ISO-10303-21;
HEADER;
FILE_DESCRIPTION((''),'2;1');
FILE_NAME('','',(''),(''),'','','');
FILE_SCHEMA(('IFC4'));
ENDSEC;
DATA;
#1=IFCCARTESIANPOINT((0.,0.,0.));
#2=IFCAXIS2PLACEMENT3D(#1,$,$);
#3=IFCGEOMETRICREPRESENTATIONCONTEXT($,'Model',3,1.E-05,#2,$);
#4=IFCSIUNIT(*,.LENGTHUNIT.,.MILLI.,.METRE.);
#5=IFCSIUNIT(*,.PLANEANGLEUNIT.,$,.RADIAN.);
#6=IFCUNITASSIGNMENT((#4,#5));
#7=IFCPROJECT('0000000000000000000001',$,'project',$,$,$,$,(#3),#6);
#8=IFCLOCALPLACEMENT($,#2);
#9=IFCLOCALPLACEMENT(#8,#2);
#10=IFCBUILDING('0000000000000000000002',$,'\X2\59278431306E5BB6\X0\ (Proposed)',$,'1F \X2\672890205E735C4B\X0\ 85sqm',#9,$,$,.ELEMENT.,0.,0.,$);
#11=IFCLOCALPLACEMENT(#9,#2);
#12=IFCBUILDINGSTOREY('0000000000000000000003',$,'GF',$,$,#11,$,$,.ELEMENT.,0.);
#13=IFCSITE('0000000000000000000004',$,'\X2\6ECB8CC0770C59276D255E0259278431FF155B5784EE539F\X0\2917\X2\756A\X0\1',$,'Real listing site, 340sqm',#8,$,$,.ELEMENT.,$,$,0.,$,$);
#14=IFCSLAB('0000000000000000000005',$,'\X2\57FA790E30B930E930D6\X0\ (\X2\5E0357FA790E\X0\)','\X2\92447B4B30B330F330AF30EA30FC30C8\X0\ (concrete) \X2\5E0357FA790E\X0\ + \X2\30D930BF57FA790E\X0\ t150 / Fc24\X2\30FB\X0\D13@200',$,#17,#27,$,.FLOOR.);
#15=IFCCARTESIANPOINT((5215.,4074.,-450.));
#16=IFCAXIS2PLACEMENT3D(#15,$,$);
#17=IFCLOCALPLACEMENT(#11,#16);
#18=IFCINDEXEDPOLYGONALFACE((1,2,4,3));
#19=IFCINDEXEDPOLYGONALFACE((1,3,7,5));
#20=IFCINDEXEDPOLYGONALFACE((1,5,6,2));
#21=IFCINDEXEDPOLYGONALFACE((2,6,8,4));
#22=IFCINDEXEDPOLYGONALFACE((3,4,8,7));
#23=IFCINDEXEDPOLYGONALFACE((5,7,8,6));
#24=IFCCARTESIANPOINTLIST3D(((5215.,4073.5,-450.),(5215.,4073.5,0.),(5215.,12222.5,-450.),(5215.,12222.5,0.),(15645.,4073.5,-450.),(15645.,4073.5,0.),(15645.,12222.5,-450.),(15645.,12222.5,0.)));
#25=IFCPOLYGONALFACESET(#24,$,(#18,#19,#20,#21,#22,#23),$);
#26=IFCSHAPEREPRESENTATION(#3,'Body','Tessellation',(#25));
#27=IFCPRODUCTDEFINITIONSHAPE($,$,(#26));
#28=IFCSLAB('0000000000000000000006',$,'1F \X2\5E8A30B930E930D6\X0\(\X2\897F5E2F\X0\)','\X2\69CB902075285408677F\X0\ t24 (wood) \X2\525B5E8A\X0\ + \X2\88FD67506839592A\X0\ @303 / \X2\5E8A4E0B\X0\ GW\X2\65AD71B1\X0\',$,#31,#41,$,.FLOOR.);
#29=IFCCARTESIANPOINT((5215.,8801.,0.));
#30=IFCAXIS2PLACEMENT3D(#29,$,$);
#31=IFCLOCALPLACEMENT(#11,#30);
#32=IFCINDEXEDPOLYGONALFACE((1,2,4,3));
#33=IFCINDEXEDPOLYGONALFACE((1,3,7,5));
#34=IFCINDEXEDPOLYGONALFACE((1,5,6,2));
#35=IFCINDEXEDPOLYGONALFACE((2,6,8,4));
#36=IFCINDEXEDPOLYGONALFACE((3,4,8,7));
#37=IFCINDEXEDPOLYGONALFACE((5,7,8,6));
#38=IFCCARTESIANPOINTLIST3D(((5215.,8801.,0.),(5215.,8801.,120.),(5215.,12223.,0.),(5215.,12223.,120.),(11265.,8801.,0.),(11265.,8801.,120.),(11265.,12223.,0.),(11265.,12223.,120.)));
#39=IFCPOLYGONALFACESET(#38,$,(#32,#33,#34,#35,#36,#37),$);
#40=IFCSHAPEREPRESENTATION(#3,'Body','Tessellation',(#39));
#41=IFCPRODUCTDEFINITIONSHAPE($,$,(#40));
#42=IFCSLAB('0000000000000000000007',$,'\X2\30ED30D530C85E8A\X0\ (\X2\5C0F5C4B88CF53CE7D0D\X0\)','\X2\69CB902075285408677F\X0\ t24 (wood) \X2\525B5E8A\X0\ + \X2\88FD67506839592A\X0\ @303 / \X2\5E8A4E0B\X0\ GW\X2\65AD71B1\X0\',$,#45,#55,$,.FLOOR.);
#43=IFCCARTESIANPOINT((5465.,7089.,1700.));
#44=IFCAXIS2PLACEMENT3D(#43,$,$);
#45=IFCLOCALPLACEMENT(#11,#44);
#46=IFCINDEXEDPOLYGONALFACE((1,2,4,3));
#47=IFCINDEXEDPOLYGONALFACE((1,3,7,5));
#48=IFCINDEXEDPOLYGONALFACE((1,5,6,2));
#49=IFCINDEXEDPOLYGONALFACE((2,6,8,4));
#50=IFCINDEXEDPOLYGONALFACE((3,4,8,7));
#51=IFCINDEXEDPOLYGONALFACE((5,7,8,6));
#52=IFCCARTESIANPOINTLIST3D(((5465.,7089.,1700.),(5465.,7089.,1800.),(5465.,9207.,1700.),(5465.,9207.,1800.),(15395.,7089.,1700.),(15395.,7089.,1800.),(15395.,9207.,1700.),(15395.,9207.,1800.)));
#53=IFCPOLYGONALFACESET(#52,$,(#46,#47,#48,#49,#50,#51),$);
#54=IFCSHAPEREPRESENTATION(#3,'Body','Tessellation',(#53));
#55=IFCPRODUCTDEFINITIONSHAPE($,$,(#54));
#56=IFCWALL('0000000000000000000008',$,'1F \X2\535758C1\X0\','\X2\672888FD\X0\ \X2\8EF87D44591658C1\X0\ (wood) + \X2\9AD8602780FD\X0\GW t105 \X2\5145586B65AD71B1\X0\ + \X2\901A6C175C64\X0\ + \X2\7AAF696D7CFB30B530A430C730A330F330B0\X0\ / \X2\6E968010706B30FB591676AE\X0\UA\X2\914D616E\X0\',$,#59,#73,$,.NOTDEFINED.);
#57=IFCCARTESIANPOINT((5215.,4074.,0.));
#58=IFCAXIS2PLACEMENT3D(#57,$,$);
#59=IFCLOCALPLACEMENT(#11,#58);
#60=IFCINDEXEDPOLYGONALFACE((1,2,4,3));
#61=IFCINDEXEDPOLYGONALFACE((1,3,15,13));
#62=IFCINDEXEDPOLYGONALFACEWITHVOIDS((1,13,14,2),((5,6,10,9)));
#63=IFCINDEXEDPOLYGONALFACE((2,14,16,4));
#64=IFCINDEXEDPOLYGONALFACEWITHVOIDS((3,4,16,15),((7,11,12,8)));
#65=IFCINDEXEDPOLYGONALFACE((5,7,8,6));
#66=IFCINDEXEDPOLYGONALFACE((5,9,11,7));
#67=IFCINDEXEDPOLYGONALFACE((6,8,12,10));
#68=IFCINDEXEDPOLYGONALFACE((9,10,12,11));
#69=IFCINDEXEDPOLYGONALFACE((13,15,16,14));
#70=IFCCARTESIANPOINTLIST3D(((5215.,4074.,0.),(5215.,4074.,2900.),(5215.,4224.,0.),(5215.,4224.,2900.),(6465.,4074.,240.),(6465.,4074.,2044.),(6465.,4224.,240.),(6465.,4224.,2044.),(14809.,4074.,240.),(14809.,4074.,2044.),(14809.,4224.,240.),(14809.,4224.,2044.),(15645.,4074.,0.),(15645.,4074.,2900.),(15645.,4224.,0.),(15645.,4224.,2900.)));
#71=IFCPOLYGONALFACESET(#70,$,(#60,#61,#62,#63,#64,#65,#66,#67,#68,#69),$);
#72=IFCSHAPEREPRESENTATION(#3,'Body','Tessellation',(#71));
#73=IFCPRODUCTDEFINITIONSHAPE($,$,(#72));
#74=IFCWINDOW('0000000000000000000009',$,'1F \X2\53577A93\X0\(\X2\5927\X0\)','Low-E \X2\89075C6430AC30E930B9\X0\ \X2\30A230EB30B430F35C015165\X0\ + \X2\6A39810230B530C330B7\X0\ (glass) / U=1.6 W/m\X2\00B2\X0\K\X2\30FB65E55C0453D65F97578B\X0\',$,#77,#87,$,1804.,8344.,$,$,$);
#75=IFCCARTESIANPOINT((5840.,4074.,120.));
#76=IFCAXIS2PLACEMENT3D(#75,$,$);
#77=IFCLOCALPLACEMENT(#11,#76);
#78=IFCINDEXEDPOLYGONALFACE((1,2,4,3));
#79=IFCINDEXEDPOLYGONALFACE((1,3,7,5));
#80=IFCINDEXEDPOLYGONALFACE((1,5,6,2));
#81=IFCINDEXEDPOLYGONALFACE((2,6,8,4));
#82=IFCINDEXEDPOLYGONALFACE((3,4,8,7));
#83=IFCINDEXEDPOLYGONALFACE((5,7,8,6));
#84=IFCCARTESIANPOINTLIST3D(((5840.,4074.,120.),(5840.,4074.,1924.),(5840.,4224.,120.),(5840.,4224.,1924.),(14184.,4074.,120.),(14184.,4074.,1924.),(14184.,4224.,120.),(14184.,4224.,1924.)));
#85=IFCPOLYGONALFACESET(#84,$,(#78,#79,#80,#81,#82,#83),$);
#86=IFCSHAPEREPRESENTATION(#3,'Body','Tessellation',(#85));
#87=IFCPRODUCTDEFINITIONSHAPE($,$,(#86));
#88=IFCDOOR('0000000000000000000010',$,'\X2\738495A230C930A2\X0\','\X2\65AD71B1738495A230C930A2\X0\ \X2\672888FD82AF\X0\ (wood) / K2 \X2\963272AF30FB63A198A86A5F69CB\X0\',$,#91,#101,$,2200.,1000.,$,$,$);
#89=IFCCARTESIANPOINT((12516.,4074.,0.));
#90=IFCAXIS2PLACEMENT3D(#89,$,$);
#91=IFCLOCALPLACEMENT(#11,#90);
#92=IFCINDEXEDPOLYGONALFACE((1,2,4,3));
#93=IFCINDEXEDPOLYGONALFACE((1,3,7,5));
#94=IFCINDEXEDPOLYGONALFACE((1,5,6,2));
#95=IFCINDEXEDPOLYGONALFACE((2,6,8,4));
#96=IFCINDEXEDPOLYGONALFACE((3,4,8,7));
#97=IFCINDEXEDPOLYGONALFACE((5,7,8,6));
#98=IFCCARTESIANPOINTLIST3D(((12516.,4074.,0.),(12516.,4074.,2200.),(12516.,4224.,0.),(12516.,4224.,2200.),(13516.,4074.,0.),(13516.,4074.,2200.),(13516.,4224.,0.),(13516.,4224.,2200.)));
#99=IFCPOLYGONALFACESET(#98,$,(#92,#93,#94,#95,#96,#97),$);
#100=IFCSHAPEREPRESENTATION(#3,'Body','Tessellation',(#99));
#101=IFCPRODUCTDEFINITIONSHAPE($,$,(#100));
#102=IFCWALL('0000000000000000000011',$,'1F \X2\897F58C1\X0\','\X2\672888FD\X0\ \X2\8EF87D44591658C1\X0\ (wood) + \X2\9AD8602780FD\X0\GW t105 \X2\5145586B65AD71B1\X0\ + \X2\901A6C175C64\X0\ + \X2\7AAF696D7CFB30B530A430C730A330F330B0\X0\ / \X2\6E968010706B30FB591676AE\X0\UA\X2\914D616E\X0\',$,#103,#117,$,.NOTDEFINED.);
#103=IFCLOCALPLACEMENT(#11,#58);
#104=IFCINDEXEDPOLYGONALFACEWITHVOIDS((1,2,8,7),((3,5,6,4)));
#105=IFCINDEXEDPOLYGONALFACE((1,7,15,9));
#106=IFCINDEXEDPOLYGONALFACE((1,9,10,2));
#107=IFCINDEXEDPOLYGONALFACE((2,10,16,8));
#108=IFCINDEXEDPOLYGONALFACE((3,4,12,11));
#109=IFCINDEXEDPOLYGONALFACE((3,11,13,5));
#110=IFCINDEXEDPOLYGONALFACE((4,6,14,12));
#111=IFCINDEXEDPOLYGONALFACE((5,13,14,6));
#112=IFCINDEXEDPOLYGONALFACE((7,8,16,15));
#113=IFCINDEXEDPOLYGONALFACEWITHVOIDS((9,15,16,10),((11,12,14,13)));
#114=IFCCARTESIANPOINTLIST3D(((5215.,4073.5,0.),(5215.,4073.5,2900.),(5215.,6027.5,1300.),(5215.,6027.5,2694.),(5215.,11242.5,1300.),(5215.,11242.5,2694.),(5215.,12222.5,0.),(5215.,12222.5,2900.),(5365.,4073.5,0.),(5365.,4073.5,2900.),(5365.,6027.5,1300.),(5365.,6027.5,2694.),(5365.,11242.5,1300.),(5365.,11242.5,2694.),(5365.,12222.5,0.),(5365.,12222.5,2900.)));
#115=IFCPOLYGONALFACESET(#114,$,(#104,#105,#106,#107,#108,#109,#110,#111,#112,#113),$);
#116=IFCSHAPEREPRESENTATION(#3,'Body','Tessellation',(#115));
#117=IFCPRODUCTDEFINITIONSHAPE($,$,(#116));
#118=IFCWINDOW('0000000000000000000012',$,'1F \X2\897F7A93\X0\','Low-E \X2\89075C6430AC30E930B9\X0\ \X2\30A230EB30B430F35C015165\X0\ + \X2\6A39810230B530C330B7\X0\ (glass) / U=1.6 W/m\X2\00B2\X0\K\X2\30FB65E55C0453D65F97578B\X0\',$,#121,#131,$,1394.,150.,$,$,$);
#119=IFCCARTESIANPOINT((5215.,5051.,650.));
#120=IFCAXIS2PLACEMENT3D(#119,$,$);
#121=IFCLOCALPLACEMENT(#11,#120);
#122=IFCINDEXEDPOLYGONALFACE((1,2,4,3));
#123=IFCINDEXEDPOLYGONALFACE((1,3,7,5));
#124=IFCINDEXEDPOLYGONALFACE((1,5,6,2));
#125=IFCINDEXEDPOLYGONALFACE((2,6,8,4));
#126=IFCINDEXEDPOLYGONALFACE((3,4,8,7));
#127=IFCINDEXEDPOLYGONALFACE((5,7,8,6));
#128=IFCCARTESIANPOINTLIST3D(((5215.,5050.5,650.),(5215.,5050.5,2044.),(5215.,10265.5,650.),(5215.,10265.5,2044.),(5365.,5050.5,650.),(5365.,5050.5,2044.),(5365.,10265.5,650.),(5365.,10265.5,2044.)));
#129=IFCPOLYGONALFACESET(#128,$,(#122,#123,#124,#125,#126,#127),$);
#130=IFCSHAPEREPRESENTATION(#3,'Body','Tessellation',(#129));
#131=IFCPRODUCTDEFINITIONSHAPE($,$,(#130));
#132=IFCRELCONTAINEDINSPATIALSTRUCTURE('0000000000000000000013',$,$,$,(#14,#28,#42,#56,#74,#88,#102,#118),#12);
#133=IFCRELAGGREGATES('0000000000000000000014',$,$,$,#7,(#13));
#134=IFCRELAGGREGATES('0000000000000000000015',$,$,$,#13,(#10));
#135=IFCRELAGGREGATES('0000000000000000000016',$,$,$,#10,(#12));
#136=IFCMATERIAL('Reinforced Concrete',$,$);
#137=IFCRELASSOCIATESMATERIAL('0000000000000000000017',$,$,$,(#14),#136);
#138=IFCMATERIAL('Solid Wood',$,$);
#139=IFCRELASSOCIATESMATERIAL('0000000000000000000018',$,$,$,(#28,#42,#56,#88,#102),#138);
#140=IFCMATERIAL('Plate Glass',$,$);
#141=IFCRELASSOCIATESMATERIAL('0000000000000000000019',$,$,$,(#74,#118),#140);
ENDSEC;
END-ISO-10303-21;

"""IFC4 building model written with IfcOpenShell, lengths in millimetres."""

from ifc_helpers import new_model, si_unit, frame, frame_2d, origin, place, context, project, spatial, rectangle, extrude, material, element, fill, save


model = new_model("IFC4")

# Units and contexts
model_context = context("Model", 3, precision=1e-05, world=origin())
ifc_project = project(units=[si_unit("LENGTHUNIT", "METRE", prefix="MILLI"), si_unit("PLANEANGLEUNIT", "RADIAN")], contexts=[model_context])

# Site, building, storey
site_placement = place(None, origin())
site = spatial("IfcSite", under=ifc_project, at=site_placement, Name="滋賀県大津市大萱５字蓮原2917番1", ObjectType="Real listing site, 340sqm", CompositionType="ELEMENT", RefElevation=0.0)
building_placement = place(site_placement, origin())
building = spatial("IfcBuilding", under=site, at=building_placement, Name="大萱の家 (Proposed)", ObjectType="1F 木造平屋 85sqm", CompositionType="ELEMENT", ElevationOfRefHeight=0.0, ElevationOfTerrain=0.0)
storey_placement = place(building_placement, origin())
storey = spatial("IfcBuildingStorey", under=building, at=storey_placement, Name="GF", CompositionType="ELEMENT", Elevation=0.0)

# Slabs
ifc_material_1 = material(Name="Reinforced Concrete")
slab_1_placement = place(storey_placement, frame((5215.0, 4074.0, -450.0)))
element("IfcSlab", 1, at=slab_1_placement, inside=storey, material=ifc_material_1, Name="基礎スラブ (布基礎)", Description="鉄筋コンクリート (concrete) 布基礎 + ベタ基礎 t150 / Fc24・D13@200", PredefinedType="FLOOR", context=model_context, shape_type="SweptSolid", body=[
    extrude(rectangle(XDim=10430.0, YDim=8149.0, at=frame_2d((5215.0, 4074.0))), frame((5215.0, 4074.0, -450.0)), (0.0, 0.0, 1.0), 450.0),
])
ifc_material_2 = material(Name="Solid Wood")
slab_2_placement = place(storey_placement, frame((5215.0, 8801.0, 0.0)))
element("IfcSlab", 2, at=slab_2_placement, inside=storey, material=ifc_material_2, Name="1F 床スラブ(西帯)", Description="構造用合板 t24 (wood) 剛床 + 製材根太 @303 / 床下 GW断熱", PredefinedType="FLOOR", context=model_context, shape_type="SweptSolid", body=[
    extrude(rectangle(XDim=6050.0, YDim=3422.0, at=frame_2d((3025.0, 1711.0))), frame((5215.0, 8801.0, 0.0)), (0.0, 0.0, 1.0), 120.0),
])
slab_3_placement = place(storey_placement, frame((5465.0, 7089.0, 1700.0)))
element("IfcSlab", 3, at=slab_3_placement, inside=storey, material=ifc_material_2, Name="ロフト床 (小屋裏収納)", Description="構造用合板 t24 (wood) 剛床 + 製材根太 @303 / 床下 GW断熱", PredefinedType="FLOOR", context=model_context, shape_type="SweptSolid", body=[
    extrude(rectangle(XDim=9930.0, YDim=2118.0, at=frame_2d((4965.0, 1059.0))), frame((5465.0, 7089.0, 1700.0)), (0.0, 0.0, 1.0), 100.0),
])

# Wall, openings, window, door
wall_1_placement = place(storey_placement, frame((5215.0, 4074.0, 0.0)))
wall_1 = element("IfcWall", 4, at=wall_1_placement, inside=storey, material=ifc_material_2, Name="1F 南壁", Description="木製 軸組外壁 (wood) + 高性能GW t105 充填断熱 + 通気層 + 窯業系サイディング / 準耐火・外皮UA配慮", PredefinedType="NOTDEFINED", context=model_context, shape_type="SweptSolid", body=[
    extrude(rectangle(XDim=10430.0, YDim=150.0, at=frame_2d((5215.0, 75.0))), frame((5215.0, 4074.0, 0.0)), (0.0, 0.0, 1.0), 2900.0),
])
opening_1_placement = place(storey_placement, frame((5840.0, 4074.0, 120.0)))
opening_1 = element("IfcOpeningElement", 5, at=opening_1_placement, cuts=wall_1, PredefinedType="NOTDEFINED", context=model_context, shape_type="SweptSolid", body=[
    extrude(rectangle(XDim=8344.0, YDim=150.0, at=frame_2d((4172.0, 75.0))), frame((5840.0, 4074.0, 120.0)), (0.0, 0.0, 1.0), 1804.0),
])
opening_2_placement = place(storey_placement, frame((12516.0, 4074.0, 0.0)))
opening_2 = element("IfcOpeningElement", 6, at=opening_2_placement, cuts=wall_1, PredefinedType="NOTDEFINED", context=model_context, shape_type="SweptSolid", body=[
    extrude(rectangle(XDim=1000.0, YDim=150.0, at=frame_2d((500.0, 75.0))), frame((12516.0, 4074.0, 0.0)), (0.0, 0.0, 1.0), 2200.0),
])
ifc_material_3 = material(Name="Plate Glass")
window_1_placement = place(storey_placement, frame((5840.0, 4074.0, 120.0)))
window_1 = element("IfcWindow", 7, at=window_1_placement, inside=storey, material=ifc_material_3, Name="1F 南窓(大)", Description="Low-E 複層ガラス アルゴン封入 + 樹脂サッシ (glass) / U=1.6 W/m²K・日射取得型", OverallHeight=1804.0, OverallWidth=8344.0, context=model_context, shape_type="SweptSolid", body=[
    extrude(rectangle(XDim=8344.0, YDim=150.0, at=frame_2d((4172.0, 75.0))), frame((5840.0, 4074.0, 120.0)), (0.0, 0.0, 1.0), 1804.0),
])
fill(opening_1, window_1)
door_placement = place(storey_placement, frame((12516.0, 4074.0, 0.0)))
door = element("IfcDoor", 8, at=door_placement, inside=storey, material=ifc_material_2, Name="玄関ドア", Description="断熱玄関ドア 木製芯 (wood) / K2 防犯・採風機構", OverallHeight=2200.0, OverallWidth=1000.0, context=model_context, shape_type="SweptSolid", body=[
    extrude(rectangle(XDim=1000.0, YDim=150.0, at=frame_2d((500.0, 75.0))), frame((12516.0, 4074.0, 0.0)), (0.0, 0.0, 1.0), 2200.0),
])
fill(opening_2, door)

# Wall, opening, window
wall_2_placement = place(storey_placement, frame((5215.0, 4074.0, 0.0)))
wall_2 = element("IfcWall", 9, at=wall_2_placement, inside=storey, material=ifc_material_2, Name="1F 西壁", Description="木製 軸組外壁 (wood) + 高性能GW t105 充填断熱 + 通気層 + 窯業系サイディング / 準耐火・外皮UA配慮", PredefinedType="NOTDEFINED", context=model_context, shape_type="SweptSolid", body=[
    extrude(rectangle(XDim=150.0, YDim=8149.0, at=frame_2d((75.0, 4074.0))), frame((5215.0, 4074.0, 0.0)), (0.0, 0.0, 1.0), 2900.0),
])
opening_3_placement = place(storey_placement, frame((5215.0, 5051.0, 650.0)))
opening_3 = element("IfcOpeningElement", 10, at=opening_3_placement, cuts=wall_2, PredefinedType="NOTDEFINED", context=model_context, shape_type="SweptSolid", body=[
    extrude(rectangle(XDim=150.0, YDim=5215.0, at=frame_2d((75.0, 2607.0))), frame((5215.0, 5051.0, 650.0)), (0.0, 0.0, 1.0), 1394.0),
])
window_2_placement = place(storey_placement, frame((5215.0, 5051.0, 650.0)))
window_2 = element("IfcWindow", 11, at=window_2_placement, inside=storey, material=ifc_material_3, Name="1F 西窓", Description="Low-E 複層ガラス アルゴン封入 + 樹脂サッシ (glass) / U=1.6 W/m²K・日射取得型", OverallHeight=1394.0, OverallWidth=150.0, context=model_context, shape_type="SweptSolid", body=[
    extrude(rectangle(XDim=150.0, YDim=5215.0, at=frame_2d((75.0, 2607.0))), frame((5215.0, 5051.0, 650.0)), (0.0, 0.0, 1.0), 1394.0),
])
fill(opening_3, window_2)

save(model, "model.ifc")
